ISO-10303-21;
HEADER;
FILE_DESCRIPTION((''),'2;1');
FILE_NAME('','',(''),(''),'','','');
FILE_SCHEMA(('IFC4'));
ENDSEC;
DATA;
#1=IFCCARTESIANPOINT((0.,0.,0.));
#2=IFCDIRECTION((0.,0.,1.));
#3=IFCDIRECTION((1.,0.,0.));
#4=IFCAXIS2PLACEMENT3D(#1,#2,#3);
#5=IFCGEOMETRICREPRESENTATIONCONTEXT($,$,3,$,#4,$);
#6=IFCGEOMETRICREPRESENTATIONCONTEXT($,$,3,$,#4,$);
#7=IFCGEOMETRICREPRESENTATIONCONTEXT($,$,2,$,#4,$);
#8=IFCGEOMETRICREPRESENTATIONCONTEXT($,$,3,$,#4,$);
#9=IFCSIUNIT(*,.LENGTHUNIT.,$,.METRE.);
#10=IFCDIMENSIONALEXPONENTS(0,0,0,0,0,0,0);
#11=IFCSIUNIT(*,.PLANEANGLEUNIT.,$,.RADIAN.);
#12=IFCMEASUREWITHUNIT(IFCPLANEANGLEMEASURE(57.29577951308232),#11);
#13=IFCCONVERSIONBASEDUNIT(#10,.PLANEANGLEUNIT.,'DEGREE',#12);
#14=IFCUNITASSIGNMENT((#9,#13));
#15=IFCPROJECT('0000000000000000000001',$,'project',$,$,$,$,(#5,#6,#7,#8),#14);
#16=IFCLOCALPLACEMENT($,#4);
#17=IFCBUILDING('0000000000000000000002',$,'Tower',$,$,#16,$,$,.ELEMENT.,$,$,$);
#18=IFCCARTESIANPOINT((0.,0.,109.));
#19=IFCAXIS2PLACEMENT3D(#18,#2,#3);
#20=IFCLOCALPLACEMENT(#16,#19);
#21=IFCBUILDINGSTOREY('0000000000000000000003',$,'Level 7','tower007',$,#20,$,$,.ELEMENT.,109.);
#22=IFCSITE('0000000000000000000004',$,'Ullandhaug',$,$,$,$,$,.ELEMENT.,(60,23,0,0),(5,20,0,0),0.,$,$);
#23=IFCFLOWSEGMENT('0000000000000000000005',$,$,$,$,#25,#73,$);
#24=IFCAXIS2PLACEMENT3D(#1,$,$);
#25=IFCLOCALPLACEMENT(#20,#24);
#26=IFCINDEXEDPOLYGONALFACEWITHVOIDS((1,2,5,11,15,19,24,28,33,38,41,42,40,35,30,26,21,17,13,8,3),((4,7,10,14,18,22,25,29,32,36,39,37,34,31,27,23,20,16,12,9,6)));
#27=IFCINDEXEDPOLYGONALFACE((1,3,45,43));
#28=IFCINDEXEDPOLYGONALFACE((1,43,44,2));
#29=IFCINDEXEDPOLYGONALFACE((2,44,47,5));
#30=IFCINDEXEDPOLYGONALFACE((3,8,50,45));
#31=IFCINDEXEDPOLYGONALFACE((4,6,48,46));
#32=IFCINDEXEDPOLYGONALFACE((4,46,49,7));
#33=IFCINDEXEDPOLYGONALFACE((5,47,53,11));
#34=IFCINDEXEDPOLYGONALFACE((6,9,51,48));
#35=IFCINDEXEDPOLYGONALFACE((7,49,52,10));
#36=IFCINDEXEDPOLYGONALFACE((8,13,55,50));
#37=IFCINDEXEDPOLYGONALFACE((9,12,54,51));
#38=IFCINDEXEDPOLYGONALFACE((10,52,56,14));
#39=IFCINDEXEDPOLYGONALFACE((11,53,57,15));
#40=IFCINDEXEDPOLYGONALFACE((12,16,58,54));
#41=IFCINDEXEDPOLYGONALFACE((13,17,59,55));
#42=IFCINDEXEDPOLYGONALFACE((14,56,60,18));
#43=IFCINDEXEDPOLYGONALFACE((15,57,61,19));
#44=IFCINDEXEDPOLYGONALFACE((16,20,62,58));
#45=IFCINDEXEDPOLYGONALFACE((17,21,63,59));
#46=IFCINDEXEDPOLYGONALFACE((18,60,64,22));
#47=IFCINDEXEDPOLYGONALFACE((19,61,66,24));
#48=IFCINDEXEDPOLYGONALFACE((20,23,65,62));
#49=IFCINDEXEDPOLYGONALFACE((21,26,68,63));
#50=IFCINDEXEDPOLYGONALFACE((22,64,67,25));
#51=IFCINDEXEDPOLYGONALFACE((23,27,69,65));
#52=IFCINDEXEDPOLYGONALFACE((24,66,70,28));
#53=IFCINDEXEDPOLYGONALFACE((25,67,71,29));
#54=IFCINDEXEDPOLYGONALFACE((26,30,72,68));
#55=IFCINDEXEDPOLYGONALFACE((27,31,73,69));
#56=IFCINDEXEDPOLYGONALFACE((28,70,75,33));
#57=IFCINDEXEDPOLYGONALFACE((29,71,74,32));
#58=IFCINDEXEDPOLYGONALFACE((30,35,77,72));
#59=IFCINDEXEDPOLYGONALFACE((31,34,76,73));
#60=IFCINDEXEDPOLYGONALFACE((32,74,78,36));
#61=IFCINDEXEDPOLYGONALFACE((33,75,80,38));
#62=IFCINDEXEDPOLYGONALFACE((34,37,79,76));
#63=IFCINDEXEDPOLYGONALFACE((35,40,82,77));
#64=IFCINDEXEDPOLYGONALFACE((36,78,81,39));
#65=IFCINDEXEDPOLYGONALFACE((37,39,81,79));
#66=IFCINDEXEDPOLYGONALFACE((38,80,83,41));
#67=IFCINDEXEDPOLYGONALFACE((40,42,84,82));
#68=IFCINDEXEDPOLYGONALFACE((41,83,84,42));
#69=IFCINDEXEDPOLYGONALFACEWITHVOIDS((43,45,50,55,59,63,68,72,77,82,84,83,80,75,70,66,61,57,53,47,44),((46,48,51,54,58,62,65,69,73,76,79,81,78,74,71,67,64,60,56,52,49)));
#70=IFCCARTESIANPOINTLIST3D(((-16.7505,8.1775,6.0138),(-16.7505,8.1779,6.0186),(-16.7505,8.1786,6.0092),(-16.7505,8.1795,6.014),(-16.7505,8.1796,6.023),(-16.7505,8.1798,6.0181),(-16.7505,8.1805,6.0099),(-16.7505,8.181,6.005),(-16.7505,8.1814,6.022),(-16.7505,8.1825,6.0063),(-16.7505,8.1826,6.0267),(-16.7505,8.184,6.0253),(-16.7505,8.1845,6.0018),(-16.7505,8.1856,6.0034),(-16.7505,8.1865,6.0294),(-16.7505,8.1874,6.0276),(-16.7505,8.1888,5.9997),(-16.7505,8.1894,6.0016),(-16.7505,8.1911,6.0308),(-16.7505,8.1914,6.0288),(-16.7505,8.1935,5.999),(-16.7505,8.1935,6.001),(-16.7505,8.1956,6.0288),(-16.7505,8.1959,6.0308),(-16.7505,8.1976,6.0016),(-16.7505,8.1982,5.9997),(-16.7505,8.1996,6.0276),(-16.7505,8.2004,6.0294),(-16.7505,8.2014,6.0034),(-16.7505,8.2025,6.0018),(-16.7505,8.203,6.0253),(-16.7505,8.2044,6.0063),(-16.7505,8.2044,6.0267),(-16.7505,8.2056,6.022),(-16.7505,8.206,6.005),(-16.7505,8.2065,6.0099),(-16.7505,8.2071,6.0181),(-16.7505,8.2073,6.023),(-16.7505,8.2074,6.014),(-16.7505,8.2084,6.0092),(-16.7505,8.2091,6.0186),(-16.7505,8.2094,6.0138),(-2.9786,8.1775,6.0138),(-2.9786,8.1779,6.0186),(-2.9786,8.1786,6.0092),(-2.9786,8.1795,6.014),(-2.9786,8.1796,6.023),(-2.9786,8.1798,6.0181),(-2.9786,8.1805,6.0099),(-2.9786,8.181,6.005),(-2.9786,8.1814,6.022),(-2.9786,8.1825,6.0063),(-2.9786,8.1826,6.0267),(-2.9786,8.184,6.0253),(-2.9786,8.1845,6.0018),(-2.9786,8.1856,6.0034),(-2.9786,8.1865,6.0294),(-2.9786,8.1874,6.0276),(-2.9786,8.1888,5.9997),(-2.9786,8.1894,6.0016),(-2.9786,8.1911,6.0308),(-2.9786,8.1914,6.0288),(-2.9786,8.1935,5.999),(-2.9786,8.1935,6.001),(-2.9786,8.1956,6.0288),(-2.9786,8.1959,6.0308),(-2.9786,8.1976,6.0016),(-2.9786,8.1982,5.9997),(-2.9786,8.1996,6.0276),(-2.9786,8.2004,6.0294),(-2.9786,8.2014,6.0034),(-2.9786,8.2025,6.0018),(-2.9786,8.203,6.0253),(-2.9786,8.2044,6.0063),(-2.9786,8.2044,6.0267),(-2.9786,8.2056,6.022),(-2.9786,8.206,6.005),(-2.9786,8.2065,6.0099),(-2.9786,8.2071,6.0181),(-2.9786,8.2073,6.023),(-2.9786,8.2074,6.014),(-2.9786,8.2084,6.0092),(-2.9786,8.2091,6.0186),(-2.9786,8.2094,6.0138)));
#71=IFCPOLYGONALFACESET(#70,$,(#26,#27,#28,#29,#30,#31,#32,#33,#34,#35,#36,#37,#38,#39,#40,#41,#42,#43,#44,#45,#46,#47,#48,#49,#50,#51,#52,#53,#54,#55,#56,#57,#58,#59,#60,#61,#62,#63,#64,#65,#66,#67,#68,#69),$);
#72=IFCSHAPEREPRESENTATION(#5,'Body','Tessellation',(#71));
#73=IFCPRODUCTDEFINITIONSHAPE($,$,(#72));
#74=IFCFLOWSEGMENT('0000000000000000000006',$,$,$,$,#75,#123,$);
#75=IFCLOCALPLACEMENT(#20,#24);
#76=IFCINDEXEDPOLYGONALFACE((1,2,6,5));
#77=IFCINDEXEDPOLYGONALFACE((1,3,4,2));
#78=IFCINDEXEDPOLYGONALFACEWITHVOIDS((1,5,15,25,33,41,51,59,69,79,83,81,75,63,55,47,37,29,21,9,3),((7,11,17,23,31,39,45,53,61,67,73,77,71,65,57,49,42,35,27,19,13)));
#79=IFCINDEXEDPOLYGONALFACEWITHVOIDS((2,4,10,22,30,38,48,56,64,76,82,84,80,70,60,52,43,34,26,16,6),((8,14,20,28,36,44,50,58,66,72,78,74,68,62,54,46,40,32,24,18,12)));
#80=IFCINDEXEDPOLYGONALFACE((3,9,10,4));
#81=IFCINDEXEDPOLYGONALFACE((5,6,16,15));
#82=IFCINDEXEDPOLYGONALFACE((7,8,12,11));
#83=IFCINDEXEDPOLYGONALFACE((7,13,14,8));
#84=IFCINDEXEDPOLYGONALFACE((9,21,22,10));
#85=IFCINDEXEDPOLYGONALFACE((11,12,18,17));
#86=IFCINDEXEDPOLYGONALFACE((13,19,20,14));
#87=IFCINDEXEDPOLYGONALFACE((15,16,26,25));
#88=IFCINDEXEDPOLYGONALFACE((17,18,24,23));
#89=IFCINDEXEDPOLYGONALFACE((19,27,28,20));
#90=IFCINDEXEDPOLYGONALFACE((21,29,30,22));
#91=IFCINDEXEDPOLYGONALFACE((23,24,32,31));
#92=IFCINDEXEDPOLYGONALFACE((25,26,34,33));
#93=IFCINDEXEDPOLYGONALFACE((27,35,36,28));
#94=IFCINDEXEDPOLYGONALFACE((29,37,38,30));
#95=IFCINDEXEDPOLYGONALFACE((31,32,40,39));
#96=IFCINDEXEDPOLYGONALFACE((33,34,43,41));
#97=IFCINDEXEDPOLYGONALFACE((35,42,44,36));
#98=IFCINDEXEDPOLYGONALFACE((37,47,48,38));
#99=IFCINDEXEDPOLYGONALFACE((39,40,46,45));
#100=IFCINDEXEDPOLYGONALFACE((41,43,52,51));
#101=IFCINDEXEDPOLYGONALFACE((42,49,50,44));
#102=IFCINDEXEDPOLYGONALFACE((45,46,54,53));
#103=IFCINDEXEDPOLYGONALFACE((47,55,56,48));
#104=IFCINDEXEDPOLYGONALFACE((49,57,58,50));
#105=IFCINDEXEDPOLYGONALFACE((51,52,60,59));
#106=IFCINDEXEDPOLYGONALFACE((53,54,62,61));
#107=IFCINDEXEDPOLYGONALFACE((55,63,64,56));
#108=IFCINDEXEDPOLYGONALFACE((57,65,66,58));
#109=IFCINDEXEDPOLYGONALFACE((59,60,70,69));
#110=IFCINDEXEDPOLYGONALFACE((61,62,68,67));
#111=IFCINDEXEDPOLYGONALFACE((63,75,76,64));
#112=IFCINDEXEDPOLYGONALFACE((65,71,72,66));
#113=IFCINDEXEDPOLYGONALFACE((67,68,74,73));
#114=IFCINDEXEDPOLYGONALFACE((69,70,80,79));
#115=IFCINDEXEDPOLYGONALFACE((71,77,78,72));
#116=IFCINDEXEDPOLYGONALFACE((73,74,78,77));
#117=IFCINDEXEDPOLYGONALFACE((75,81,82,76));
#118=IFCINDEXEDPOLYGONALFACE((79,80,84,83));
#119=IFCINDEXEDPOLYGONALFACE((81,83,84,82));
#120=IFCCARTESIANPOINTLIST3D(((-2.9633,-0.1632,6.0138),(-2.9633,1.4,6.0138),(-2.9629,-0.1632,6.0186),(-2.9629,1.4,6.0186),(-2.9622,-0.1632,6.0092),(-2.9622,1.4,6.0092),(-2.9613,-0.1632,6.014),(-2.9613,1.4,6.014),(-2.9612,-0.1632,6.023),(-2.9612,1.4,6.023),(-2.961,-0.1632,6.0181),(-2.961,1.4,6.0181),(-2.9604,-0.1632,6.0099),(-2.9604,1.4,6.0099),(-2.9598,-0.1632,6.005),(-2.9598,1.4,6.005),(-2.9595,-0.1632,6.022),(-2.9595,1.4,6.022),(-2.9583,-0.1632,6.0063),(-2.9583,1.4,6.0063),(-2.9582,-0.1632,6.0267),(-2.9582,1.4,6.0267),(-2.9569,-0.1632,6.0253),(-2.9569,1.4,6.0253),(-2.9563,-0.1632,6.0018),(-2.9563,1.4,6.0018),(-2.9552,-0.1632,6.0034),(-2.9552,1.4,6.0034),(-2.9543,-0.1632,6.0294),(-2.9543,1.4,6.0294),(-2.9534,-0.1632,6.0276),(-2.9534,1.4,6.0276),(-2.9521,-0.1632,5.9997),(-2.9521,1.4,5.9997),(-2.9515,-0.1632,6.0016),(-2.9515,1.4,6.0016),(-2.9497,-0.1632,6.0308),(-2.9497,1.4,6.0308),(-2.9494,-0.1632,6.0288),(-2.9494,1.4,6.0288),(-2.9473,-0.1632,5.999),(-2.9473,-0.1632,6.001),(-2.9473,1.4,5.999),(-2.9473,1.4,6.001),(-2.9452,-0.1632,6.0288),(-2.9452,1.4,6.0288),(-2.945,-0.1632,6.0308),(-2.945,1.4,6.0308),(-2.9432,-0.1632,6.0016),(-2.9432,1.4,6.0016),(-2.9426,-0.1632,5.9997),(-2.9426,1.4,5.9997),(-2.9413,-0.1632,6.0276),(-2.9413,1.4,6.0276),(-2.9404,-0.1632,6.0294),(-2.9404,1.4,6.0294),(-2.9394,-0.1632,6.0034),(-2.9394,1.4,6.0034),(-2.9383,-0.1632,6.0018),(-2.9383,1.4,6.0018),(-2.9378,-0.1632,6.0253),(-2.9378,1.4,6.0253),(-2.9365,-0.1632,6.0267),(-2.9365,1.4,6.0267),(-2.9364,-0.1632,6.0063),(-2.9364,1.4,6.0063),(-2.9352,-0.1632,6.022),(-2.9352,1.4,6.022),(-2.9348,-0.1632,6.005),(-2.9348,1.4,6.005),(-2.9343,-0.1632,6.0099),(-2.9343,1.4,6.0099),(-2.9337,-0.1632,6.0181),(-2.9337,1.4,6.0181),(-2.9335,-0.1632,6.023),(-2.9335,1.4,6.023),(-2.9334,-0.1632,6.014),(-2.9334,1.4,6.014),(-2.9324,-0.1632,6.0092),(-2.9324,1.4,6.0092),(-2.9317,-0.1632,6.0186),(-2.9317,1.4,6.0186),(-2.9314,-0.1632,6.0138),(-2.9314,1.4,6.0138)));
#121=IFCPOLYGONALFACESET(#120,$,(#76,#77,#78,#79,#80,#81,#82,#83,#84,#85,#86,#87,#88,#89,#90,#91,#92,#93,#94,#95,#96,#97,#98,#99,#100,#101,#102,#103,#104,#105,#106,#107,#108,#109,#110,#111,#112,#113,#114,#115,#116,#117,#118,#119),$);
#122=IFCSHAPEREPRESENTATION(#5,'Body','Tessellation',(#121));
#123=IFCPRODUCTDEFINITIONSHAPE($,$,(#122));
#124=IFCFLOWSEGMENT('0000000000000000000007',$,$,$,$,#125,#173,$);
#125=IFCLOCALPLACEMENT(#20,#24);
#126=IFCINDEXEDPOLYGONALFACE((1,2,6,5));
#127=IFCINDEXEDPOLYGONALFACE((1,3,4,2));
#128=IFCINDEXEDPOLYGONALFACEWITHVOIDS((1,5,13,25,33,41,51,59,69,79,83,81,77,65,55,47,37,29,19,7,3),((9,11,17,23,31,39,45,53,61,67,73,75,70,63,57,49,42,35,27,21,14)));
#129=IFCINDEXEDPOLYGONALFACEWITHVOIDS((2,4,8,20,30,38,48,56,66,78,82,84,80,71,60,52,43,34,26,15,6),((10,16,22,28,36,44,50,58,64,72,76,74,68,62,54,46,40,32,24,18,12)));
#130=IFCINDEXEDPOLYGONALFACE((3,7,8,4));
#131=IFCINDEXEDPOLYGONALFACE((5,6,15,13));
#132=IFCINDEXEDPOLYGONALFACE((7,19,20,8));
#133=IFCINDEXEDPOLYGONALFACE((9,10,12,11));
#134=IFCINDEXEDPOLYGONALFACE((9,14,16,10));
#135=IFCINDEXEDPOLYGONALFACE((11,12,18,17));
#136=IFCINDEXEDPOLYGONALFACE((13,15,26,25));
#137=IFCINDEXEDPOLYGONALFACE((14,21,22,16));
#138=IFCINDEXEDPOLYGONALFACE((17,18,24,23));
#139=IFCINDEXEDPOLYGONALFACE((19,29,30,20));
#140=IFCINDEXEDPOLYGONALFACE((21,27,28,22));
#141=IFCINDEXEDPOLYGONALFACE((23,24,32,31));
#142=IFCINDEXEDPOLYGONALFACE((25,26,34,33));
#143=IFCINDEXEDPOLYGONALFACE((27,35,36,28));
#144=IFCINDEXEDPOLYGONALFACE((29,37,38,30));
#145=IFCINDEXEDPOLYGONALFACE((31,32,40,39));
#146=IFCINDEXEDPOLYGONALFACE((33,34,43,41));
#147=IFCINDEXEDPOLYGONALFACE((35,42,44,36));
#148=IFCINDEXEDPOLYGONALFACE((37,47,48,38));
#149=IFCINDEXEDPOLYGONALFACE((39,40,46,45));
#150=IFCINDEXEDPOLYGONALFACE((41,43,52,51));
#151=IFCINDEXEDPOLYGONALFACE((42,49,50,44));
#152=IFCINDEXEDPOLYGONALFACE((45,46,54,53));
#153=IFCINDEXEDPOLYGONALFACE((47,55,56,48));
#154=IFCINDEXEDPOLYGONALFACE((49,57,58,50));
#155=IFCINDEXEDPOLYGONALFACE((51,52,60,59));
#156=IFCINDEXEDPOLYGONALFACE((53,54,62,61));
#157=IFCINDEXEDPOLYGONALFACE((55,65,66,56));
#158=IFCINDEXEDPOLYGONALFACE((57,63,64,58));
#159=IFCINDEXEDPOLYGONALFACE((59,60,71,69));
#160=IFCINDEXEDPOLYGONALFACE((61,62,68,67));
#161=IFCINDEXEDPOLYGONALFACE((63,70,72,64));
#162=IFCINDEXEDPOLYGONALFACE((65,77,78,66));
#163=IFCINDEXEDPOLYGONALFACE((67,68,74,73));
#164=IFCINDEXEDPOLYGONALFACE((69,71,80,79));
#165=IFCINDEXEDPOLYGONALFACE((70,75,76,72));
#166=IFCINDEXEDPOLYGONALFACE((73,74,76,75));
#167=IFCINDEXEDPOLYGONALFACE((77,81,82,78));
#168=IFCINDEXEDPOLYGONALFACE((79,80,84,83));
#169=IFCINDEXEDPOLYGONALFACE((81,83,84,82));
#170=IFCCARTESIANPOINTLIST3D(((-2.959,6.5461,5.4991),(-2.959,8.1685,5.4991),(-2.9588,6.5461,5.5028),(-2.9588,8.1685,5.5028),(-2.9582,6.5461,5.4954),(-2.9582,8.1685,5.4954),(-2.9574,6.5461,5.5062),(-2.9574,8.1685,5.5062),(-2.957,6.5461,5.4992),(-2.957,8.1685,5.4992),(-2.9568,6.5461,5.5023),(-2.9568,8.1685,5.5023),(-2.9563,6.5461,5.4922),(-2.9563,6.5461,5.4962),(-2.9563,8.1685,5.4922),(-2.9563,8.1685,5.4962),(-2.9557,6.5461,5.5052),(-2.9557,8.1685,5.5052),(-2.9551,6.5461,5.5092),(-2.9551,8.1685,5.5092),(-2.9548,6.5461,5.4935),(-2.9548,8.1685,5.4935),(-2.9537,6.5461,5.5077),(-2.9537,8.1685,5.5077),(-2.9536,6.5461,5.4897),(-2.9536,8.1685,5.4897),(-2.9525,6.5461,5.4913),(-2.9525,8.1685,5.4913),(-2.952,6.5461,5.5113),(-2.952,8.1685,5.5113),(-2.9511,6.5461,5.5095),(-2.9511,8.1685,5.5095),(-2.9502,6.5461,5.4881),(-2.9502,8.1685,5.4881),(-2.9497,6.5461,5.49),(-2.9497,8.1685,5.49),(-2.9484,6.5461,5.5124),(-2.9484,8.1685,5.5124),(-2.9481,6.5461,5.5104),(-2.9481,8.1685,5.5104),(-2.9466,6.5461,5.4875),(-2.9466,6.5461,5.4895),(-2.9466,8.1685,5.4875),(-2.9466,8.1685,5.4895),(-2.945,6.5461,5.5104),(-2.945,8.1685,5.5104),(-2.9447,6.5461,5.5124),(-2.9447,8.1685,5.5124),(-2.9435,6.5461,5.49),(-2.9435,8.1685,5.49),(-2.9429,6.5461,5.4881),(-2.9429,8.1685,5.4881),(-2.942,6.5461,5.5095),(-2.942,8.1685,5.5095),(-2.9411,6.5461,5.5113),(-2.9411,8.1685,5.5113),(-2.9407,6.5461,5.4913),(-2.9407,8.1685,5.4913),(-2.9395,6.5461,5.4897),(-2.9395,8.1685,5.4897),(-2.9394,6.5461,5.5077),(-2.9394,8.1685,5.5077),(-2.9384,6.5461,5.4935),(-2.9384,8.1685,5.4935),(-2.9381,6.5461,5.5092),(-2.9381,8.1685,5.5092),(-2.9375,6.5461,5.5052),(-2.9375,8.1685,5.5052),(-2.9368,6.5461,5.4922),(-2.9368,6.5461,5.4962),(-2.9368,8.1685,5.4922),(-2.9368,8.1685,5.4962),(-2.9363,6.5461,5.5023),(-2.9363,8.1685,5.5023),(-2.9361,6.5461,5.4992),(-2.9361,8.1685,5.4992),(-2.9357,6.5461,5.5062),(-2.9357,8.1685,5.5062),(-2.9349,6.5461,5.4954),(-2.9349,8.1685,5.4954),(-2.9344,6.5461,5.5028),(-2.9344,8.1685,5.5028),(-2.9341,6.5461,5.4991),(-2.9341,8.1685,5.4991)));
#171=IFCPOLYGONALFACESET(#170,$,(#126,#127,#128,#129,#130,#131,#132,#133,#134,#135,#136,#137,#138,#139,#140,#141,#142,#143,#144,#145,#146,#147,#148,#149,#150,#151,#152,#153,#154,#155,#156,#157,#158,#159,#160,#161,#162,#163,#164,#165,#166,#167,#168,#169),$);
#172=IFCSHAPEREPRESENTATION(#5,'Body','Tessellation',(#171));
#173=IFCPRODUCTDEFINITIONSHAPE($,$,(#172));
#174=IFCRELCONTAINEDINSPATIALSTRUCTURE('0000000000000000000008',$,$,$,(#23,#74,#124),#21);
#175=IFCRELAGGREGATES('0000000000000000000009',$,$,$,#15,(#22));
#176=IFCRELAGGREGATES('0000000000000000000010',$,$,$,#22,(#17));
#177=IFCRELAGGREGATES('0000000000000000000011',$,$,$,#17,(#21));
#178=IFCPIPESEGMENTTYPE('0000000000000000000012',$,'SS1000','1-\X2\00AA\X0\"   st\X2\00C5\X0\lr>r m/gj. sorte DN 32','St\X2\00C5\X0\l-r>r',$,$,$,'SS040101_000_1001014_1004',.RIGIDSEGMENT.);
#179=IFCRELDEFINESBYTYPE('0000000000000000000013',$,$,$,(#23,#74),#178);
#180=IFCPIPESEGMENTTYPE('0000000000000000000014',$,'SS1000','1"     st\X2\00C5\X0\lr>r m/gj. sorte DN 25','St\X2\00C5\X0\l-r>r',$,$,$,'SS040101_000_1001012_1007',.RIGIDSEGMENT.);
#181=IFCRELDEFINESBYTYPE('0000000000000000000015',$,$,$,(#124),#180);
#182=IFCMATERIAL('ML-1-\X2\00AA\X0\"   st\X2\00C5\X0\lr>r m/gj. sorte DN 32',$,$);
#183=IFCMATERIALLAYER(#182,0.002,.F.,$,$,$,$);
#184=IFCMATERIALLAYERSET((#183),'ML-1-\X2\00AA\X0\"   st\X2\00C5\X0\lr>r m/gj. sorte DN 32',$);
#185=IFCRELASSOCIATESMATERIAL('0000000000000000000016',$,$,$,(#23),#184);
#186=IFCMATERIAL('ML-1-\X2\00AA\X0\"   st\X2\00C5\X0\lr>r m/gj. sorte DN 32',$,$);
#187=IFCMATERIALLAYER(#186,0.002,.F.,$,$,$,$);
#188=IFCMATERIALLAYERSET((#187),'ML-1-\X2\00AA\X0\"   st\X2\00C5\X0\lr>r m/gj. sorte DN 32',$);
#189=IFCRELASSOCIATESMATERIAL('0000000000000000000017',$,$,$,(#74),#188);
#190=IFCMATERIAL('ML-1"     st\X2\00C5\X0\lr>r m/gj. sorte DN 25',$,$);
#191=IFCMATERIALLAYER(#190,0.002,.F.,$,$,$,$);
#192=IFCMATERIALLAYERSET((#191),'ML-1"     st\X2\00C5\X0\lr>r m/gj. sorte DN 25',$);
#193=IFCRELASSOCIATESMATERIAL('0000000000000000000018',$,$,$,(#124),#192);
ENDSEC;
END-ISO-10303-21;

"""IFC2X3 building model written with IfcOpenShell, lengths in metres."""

from ifc_helpers import new_model, entity, si_unit, converted_unit, frame, origin_with_axes, origin_2d_with_axis, place, context, project, spatial, hollow_circle, extrude, material, layer, layer_set, layer_usage, type_object, element, save


model = new_model("IFC2X3")

# Units and contexts
context_of_model_1 = context(None, 3, world=origin_with_axes())
context_of_model_2 = context(None, 3, world=origin_with_axes())
context_of_model_3 = context(None, 2, world=origin_with_axes())
context_of_model_4 = context(None, 3, world=origin_with_axes())
ifc_project = project(units=[si_unit("LENGTHUNIT", "METRE"), converted_unit("PLANEANGLEUNIT", "DEGREE", entity("IfcPlaneAngleMeasure", 57.29577951308232), si_unit("PLANEANGLEUNIT", "RADIAN"), dimensions=[0, 0, 0, 0, 0, 0, 0])], contexts=[context_of_model_1, context_of_model_2, context_of_model_3, context_of_model_4])

# Site, building, storey
site = spatial("IfcSite", under=ifc_project, Name="Ullandhaug", CompositionType="ELEMENT", RefLatitude=(60, 23, 0, 0), RefLongitude=(5, 20, 0, 0), RefElevation=0.0)
building_placement = place(None, origin_with_axes())
building = spatial("IfcBuilding", under=site, at=building_placement, Name="Tower", CompositionType="ELEMENT")
storey_placement = place(building_placement, frame((0.0, 0.0, 109.0), z_axis=(0.0, 0.0, 1.0), x_axis=(1.0, 0.0, 0.0)))
storey = spatial("IfcBuildingStorey", under=building, at=storey_placement, Name="Level 7", Description="tower007", CompositionType="ELEMENT", Elevation=109.0)

# Flow segments
pipe_segment_type_1 = type_object("IfcPipeSegmentType", Name="SS1000", Description="1-ª\"   stÅlr>r m/gj. sorte DN 32", ApplicableOccurrence="StÅl-r>r", ElementType="SS040101_000_1001014_1004", PredefinedType="RIGIDSEGMENT")
ifc_material_1 = material(Name="ML-1-ª\"   stÅlr>r m/gj. sorte DN 32")
ifc_layer_1 = layer(ifc_material_1, 0.002, ventilated=False)
ifc_layer_set_1 = layer_set([ifc_layer_1], Name="ML-1-ª\"   stÅlr>r m/gj. sorte DN 32")
ifc_layer_usage_1 = layer_usage(ifc_layer_set_1, "AXIS2", "POSITIVE", 0.0)
flow_segment_1_placement = place(storey_placement, frame((-2.9786, 8.1935, 6.015), z_axis=(-1.0, 0.0, 0.0), x_axis=(0.0, 0.0, -1.0)))
element("IfcFlowSegment", 1, at=flow_segment_1_placement, inside=storey, type_object=pipe_segment_type_1, material=ifc_layer_usage_1, context=context_of_model_1, shape_type="SweptSolid", body=[
    extrude(hollow_circle(Radius=0.016, WallThickness=0.002, at=origin_2d_with_axis()), origin_with_axes(), (0.0, 0.0, 1.0), 13.7719),
])
ifc_material_2 = material(Name="ML-1-ª\"   stÅlr>r m/gj. sorte DN 32")
ifc_layer_2 = layer(ifc_material_2, 0.002, ventilated=False)
ifc_layer_set_2 = layer_set([ifc_layer_2], Name="ML-1-ª\"   stÅlr>r m/gj. sorte DN 32")
ifc_layer_usage_2 = layer_usage(ifc_layer_set_2, "AXIS2", "POSITIVE", 0.0)
flow_segment_2_placement = place(storey_placement, frame((-2.9473, -0.1632, 6.015), z_axis=(0.0, 1.0, 0.0), x_axis=(0.0, 0.0, -1.0)))
element("IfcFlowSegment", 2, at=flow_segment_2_placement, inside=storey, type_object=pipe_segment_type_1, material=ifc_layer_usage_2, context=context_of_model_1, shape_type="SweptSolid", body=[
    extrude(hollow_circle(Radius=0.016, WallThickness=0.002, at=origin_2d_with_axis()), origin_with_axes(), (0.0, 0.0, 1.0), 1.5632),
])
ifc_material_3 = material(Name="ML-1\"     stÅlr>r m/gj. sorte DN 25")
ifc_layer_3 = layer(ifc_material_3, 0.002, ventilated=False)
ifc_layer_set_3 = layer_set([ifc_layer_3], Name="ML-1\"     stÅlr>r m/gj. sorte DN 25")
ifc_layer_usage_3 = layer_usage(ifc_layer_set_3, "AXIS2", "POSITIVE", 0.0)
pipe_segment_type_2 = type_object("IfcPipeSegmentType", Name="SS1000", Description="1\"     stÅlr>r m/gj. sorte DN 25", ApplicableOccurrence="StÅl-r>r", ElementType="SS040101_000_1001012_1007", PredefinedType="RIGIDSEGMENT")
flow_segment_3_placement = place(storey_placement, frame((-2.9466, 6.5461, 5.5), z_axis=(0.0, 1.0, 0.0), x_axis=(0.0, 0.0, -1.0)))
element("IfcFlowSegment", 3, at=flow_segment_3_placement, inside=storey, type_object=pipe_segment_type_2, material=ifc_layer_usage_3, context=context_of_model_1, shape_type="SweptSolid", body=[
    extrude(hollow_circle(Radius=0.0125, WallThickness=0.002, at=origin_2d_with_axis()), origin_with_axes(), (0.0, 0.0, 1.0), 1.6224),
])

save(model, "model.ifc")
